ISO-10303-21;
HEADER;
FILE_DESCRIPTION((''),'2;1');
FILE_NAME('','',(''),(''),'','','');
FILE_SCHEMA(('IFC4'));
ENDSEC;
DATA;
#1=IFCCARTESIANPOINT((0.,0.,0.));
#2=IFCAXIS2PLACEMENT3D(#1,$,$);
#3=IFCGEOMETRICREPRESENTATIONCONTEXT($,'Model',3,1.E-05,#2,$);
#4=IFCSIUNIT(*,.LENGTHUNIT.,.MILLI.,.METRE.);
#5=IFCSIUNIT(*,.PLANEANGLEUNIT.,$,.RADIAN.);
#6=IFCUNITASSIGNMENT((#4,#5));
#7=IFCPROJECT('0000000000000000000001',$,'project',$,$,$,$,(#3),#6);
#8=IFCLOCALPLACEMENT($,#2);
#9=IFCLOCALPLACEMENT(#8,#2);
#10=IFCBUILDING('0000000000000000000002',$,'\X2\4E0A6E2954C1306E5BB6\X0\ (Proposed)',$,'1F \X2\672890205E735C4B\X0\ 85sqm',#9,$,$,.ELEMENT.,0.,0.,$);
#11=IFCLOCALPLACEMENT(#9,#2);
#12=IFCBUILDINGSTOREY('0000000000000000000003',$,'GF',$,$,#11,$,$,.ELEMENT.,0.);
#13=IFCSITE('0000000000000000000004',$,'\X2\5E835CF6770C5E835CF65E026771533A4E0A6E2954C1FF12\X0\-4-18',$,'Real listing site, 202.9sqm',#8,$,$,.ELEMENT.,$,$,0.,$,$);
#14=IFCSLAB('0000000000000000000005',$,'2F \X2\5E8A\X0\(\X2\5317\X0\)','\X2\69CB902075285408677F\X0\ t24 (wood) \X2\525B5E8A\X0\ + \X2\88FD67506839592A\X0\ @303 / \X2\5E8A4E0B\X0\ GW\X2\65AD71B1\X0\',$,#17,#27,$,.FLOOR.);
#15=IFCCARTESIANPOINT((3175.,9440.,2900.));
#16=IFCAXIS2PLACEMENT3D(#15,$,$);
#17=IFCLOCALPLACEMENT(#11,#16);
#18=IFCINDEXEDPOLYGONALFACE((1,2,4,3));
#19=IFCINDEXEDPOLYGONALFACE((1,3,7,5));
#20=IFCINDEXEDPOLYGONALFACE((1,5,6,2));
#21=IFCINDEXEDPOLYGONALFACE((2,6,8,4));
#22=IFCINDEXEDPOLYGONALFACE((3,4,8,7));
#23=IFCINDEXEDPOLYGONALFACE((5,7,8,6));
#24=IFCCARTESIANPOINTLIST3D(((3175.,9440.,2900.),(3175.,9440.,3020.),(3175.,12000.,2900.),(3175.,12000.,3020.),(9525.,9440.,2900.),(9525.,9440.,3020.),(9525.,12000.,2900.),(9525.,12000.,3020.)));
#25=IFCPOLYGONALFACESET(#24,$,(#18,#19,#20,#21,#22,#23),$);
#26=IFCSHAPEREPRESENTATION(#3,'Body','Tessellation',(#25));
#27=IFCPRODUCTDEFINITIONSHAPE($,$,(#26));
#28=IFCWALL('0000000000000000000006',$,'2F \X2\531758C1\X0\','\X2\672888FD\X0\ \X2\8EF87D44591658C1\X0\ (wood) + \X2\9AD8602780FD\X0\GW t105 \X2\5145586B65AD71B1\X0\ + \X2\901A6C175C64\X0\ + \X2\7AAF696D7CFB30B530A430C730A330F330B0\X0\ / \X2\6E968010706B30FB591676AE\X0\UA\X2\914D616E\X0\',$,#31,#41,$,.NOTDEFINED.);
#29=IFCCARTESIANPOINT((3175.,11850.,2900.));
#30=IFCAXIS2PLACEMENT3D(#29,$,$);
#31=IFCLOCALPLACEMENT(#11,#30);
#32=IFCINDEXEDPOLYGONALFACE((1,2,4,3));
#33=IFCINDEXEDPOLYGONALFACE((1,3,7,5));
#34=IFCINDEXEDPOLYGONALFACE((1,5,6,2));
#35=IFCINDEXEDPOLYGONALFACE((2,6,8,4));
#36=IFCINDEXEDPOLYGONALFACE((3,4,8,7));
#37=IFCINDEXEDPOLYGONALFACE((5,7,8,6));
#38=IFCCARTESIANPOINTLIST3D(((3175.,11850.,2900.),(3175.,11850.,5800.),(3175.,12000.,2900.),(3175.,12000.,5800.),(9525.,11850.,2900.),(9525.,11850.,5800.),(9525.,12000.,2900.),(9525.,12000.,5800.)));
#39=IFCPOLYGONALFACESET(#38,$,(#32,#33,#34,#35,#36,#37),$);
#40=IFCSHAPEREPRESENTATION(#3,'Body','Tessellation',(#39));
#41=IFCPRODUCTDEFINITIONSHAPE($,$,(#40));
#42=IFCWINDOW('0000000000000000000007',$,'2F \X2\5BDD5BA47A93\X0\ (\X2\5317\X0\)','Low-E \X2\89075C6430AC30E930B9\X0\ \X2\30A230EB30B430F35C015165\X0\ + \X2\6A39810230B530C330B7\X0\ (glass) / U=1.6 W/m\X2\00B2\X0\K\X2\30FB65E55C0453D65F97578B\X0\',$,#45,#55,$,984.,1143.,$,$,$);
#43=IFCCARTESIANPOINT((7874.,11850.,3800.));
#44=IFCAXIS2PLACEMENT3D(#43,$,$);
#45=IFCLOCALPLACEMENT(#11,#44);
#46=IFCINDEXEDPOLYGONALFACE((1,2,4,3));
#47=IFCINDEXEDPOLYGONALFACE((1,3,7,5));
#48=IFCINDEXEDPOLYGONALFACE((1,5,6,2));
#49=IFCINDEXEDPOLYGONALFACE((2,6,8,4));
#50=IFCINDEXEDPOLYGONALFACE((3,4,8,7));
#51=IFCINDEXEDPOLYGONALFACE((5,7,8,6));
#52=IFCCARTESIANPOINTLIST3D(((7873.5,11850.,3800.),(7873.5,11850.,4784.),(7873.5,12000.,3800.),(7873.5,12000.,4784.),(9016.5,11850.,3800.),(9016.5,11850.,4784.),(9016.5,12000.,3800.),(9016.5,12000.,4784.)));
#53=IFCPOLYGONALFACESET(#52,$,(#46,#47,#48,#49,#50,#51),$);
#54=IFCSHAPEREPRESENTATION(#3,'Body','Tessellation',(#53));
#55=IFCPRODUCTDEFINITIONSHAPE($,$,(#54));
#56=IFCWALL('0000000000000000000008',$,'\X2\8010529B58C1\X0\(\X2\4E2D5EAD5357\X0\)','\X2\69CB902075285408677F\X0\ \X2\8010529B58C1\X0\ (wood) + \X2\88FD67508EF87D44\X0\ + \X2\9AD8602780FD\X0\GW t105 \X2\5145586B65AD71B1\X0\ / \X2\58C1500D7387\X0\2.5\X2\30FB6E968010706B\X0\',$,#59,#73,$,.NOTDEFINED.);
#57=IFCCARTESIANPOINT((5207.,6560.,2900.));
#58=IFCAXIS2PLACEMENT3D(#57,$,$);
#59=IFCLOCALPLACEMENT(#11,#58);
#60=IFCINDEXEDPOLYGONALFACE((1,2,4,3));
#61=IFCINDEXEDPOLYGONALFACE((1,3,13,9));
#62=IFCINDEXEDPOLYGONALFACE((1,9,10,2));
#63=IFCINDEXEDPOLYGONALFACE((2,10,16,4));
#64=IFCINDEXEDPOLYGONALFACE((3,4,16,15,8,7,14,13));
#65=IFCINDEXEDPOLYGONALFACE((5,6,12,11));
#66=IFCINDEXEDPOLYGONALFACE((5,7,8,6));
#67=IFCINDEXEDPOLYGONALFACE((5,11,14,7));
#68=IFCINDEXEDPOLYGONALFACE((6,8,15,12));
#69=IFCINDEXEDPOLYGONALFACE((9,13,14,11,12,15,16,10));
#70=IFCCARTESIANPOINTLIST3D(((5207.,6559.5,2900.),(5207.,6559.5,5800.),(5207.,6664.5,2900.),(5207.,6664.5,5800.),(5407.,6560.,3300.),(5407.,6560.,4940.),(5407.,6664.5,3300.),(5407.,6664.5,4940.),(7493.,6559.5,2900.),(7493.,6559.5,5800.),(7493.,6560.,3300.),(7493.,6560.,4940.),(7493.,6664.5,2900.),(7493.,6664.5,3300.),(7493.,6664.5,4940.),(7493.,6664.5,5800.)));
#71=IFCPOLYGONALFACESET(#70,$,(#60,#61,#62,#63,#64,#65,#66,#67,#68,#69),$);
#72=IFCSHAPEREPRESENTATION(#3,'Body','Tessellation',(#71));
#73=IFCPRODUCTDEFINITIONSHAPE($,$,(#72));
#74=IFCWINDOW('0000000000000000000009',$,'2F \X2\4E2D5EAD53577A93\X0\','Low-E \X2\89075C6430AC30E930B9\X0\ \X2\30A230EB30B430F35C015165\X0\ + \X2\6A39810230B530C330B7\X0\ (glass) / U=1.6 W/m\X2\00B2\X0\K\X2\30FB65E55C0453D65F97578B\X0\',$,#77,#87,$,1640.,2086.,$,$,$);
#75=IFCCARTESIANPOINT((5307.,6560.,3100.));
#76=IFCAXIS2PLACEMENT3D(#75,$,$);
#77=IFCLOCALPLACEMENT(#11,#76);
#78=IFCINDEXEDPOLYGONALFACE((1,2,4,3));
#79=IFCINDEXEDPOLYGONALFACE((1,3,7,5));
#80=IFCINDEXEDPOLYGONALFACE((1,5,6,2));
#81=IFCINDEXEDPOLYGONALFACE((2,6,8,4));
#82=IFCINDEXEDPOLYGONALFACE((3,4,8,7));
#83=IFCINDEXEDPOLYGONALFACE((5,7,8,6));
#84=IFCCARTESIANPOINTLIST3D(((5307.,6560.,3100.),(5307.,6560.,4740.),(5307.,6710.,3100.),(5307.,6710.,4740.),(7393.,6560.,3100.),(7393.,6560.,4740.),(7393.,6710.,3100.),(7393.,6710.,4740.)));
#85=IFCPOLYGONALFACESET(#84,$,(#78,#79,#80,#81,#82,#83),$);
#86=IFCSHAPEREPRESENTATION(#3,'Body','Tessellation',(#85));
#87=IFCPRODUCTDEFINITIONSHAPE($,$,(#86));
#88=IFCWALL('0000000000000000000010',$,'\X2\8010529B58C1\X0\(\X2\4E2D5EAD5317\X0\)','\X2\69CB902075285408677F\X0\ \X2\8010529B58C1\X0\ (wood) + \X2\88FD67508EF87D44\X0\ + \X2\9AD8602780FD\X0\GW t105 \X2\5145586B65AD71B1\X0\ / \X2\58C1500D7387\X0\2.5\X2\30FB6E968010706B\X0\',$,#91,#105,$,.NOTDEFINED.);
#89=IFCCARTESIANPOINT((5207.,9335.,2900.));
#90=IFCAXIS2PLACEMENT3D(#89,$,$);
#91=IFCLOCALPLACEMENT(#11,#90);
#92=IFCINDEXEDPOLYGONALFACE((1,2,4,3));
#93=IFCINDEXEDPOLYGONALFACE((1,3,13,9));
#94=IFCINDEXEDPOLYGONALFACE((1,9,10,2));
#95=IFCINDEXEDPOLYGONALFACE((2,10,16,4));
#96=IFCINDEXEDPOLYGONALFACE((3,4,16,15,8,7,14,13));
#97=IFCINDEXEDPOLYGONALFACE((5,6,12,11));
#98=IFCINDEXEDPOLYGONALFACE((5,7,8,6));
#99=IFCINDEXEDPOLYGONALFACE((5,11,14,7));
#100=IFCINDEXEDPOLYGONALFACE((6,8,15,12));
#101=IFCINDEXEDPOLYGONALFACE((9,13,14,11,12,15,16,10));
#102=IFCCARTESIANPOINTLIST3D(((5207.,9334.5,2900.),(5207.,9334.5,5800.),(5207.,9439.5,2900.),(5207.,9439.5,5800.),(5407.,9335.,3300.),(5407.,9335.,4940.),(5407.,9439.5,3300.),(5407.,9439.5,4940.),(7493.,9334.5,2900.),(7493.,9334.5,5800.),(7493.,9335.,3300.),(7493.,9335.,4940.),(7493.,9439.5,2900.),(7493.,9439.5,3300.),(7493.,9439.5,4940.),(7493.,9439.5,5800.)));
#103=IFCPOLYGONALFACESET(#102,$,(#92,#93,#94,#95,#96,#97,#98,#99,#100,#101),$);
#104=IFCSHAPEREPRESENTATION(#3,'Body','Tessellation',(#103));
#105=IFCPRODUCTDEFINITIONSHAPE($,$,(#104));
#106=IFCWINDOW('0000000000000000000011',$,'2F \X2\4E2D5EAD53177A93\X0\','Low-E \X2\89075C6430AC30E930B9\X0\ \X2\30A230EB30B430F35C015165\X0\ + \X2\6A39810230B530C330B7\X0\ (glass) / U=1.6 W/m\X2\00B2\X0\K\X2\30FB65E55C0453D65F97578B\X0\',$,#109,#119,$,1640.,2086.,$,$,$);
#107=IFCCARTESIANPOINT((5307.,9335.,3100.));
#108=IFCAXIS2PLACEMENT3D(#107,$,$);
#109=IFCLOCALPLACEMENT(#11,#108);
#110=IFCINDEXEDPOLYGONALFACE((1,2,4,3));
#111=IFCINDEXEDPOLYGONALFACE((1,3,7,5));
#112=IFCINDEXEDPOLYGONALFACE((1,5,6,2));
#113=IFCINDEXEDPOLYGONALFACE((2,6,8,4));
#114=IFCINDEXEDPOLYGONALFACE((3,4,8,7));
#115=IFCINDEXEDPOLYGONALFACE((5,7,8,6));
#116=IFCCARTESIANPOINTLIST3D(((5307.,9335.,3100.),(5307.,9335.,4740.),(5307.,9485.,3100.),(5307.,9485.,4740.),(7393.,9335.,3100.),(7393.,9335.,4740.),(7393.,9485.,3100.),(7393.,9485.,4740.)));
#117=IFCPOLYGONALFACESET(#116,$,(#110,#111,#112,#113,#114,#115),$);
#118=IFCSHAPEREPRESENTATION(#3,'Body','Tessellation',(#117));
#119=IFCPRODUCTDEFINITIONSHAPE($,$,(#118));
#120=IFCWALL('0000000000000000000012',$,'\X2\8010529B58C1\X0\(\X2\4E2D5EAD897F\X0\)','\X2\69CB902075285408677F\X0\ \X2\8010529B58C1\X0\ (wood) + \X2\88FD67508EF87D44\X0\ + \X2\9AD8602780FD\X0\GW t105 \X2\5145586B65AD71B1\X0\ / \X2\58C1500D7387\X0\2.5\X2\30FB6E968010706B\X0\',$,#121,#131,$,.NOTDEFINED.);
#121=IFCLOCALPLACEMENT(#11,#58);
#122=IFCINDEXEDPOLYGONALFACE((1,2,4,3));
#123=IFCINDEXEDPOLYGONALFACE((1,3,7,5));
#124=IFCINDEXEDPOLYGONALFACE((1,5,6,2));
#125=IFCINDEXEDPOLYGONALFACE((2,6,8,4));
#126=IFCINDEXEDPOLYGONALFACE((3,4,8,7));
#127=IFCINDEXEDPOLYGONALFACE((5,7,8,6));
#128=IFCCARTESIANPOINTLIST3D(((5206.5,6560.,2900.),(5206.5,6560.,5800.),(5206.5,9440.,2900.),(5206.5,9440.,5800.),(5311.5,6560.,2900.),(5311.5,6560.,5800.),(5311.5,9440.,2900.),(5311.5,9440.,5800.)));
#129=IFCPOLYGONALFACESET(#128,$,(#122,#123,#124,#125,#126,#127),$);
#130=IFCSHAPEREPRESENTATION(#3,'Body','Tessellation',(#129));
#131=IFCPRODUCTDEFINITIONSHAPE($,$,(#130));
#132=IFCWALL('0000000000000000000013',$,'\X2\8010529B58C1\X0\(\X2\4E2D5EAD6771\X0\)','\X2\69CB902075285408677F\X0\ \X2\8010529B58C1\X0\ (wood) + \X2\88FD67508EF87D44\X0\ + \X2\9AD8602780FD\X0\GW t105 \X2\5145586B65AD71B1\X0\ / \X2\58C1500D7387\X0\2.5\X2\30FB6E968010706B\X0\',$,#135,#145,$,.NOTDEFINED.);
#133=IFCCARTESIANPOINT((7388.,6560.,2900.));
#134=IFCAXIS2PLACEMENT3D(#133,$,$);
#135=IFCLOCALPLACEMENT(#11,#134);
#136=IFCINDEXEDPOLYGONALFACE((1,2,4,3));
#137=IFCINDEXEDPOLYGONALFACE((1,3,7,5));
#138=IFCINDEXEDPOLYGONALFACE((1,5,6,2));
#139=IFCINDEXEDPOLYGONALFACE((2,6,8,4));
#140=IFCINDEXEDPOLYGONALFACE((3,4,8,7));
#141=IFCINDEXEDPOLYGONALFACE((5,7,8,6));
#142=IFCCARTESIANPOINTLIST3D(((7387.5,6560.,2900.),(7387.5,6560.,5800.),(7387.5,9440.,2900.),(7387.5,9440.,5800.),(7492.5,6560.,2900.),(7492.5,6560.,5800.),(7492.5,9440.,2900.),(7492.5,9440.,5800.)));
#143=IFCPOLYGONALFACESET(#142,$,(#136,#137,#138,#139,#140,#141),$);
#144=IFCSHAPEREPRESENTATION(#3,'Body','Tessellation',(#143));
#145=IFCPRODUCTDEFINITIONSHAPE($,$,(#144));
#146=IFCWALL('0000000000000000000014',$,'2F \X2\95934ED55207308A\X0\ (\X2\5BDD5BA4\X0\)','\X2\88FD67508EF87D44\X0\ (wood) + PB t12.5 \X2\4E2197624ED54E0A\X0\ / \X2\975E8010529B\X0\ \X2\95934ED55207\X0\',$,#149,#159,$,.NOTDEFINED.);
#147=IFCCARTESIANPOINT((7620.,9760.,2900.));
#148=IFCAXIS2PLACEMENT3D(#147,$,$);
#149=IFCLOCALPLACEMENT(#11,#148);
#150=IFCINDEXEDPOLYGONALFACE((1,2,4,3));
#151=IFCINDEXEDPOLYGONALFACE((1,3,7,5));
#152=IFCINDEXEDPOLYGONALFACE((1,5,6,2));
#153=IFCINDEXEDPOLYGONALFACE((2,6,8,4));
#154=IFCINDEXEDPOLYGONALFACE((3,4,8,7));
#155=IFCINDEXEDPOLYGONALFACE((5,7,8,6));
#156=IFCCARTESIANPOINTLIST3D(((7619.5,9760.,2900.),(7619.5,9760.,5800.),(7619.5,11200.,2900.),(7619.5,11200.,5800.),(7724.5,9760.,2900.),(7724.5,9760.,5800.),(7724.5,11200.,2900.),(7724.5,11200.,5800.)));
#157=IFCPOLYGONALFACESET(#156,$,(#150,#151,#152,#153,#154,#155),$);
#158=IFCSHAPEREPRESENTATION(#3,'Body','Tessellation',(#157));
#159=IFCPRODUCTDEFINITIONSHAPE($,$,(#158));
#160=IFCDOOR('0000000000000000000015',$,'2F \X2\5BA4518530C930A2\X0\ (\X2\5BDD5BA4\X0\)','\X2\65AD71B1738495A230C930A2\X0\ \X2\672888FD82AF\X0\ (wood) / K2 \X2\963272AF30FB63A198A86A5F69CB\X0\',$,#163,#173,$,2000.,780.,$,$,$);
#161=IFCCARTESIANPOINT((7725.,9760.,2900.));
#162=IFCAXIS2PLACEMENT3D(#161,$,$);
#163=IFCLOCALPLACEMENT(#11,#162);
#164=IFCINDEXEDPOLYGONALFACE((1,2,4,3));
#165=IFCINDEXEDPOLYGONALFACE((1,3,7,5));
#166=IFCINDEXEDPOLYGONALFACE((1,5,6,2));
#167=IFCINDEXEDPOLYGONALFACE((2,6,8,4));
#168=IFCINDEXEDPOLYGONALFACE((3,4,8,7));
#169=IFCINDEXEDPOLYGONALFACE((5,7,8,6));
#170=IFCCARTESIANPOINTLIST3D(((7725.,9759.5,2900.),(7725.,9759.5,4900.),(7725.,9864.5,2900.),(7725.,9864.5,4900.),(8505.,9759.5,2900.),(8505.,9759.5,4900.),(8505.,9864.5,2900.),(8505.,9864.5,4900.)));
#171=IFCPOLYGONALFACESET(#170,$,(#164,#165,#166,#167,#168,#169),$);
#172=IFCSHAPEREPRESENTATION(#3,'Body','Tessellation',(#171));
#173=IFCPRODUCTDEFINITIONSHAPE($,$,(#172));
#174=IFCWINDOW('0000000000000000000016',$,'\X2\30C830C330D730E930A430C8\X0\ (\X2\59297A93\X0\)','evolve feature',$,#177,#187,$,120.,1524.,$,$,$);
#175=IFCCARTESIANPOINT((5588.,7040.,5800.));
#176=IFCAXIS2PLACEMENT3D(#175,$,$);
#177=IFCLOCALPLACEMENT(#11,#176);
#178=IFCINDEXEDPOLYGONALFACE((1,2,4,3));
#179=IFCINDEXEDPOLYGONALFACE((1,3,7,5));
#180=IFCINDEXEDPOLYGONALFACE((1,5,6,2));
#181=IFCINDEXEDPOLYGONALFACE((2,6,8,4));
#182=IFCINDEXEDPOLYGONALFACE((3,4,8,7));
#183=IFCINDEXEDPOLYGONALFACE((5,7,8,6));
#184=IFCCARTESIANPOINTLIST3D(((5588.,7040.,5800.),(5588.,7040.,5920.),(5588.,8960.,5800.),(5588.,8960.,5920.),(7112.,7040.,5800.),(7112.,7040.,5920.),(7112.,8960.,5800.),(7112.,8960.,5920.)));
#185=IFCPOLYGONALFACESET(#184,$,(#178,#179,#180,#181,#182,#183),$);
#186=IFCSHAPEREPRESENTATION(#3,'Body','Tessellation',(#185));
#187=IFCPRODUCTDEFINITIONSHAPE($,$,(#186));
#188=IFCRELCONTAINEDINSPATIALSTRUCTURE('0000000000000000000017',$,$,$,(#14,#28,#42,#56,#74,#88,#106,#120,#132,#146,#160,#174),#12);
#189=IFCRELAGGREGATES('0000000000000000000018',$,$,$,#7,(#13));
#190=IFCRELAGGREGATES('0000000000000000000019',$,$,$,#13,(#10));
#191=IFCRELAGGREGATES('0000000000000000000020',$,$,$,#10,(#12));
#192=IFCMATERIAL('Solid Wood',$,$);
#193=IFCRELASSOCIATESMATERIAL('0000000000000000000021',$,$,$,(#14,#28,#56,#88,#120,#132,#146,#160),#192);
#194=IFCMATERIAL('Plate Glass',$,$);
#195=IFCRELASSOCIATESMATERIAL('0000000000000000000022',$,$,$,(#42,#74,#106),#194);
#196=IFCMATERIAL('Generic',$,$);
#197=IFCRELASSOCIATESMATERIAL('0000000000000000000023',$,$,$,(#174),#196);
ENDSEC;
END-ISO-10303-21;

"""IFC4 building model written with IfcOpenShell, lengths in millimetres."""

from ifc_helpers import new_model, si_unit, frame, frame_2d, origin, place, context, project, spatial, rectangle, extrude, material, element, fill, save


model = new_model("IFC4")

# Units and contexts
model_context = context("Model", 3, precision=1e-05, world=origin())
ifc_project = project(units=[si_unit("LENGTHUNIT", "METRE", prefix="MILLI"), si_unit("PLANEANGLEUNIT", "RADIAN")], contexts=[model_context])

# Site, building, storey
site_placement = place(None, origin())
site = spatial("IfcSite", under=ifc_project, at=site_placement, Name="広島県広島市東区上温品２-4-18", ObjectType="Real listing site, 202.9sqm", CompositionType="ELEMENT", RefElevation=0.0)
building_placement = place(site_placement, origin())
building = spatial("IfcBuilding", under=site, at=building_placement, Name="上温品の家 (Proposed)", ObjectType="1F 木造平屋 85sqm", CompositionType="ELEMENT", ElevationOfRefHeight=0.0, ElevationOfTerrain=0.0)
storey_placement = place(building_placement, origin())
storey = spatial("IfcBuildingStorey", under=building, at=storey_placement, Name="GF", CompositionType="ELEMENT", Elevation=0.0)

# Slab
ifc_material_1 = material(Name="Solid Wood")
slab_placement = place(storey_placement, frame((3175.0, 9440.0, 2900.0)))
element("IfcSlab", 1, at=slab_placement, inside=storey, material=ifc_material_1, Name="2F 床(北)", Description="構造用合板 t24 (wood) 剛床 + 製材根太 @303 / 床下 GW断熱", PredefinedType="FLOOR", context=model_context, shape_type="SweptSolid", body=[
    extrude(rectangle(XDim=6350.0, YDim=2560.0, at=frame_2d((3175.0, 1280.0))), frame((3175.0, 9440.0, 2900.0)), (0.0, 0.0, 1.0), 120.0),
])

# Walls, openings, windows
wall_1_placement = place(storey_placement, frame((3175.0, 11850.0, 2900.0)))
wall_1 = element("IfcWall", 2, at=wall_1_placement, inside=storey, material=ifc_material_1, Name="2F 北壁", Description="木製 軸組外壁 (wood) + 高性能GW t105 充填断熱 + 通気層 + 窯業系サイディング / 準耐火・外皮UA配慮", PredefinedType="NOTDEFINED", context=model_context, shape_type="SweptSolid", body=[
    extrude(rectangle(XDim=6350.0, YDim=150.0, at=frame_2d((3175.0, 75.0))), frame((3175.0, 11850.0, 2900.0)), (0.0, 0.0, 1.0), 2900.0),
])
opening_1_placement = place(storey_placement, frame((7874.0, 11850.0, 3800.0)))
opening_1 = element("IfcOpeningElement", 3, at=opening_1_placement, cuts=wall_1, PredefinedType="NOTDEFINED", context=model_context, shape_type="SweptSolid", body=[
    extrude(rectangle(XDim=1143.0, YDim=150.0, at=frame_2d((571.0, 75.0))), frame((7874.0, 11850.0, 3800.0)), (0.0, 0.0, 1.0), 984.0),
])
ifc_material_2 = material(Name="Plate Glass")
window_1_placement = place(storey_placement, frame((7874.0, 11850.0, 3800.0)))
window_1 = element("IfcWindow", 4, at=window_1_placement, inside=storey, material=ifc_material_2, Name="2F 寝室窓 (北)", Description="Low-E 複層ガラス アルゴン封入 + 樹脂サッシ (glass) / U=1.6 W/m²K・日射取得型", OverallHeight=984.0, OverallWidth=1143.0, context=model_context, shape_type="SweptSolid", body=[
    extrude(rectangle(XDim=1143.0, YDim=150.0, at=frame_2d((571.0, 75.0))), frame((7874.0, 11850.0, 3800.0)), (0.0, 0.0, 1.0), 984.0),
])
fill(opening_1, window_1)
wall_2_placement = place(storey_placement, frame((5207.0, 6560.0, 2900.0)))
wall_2 = element("IfcWall", 5, at=wall_2_placement, inside=storey, material=ifc_material_1, Name="耐力壁(中庭南)", Description="構造用合板 耐力壁 (wood) + 製材軸組 + 高性能GW t105 充填断熱 / 壁倍率2.5・準耐火", PredefinedType="NOTDEFINED", context=model_context, shape_type="SweptSolid", body=[
    extrude(rectangle(XDim=2286.0, YDim=105.0, at=frame_2d((1143.0, 52.0))), frame((5207.0, 6560.0, 2900.0)), (0.0, 0.0, 1.0), 2900.0),
])
opening_2_placement = place(storey_placement, frame((5307.0, 6560.0, 3100.0)))
opening_2 = element("IfcOpeningElement", 6, at=opening_2_placement, cuts=wall_2, PredefinedType="NOTDEFINED", context=model_context, shape_type="SweptSolid", body=[
    extrude(rectangle(XDim=2086.0, YDim=150.0, at=frame_2d((1043.0, 75.0))), frame((5307.0, 6560.0, 3100.0)), (0.0, 0.0, 1.0), 1640.0),
])
window_2_placement = place(storey_placement, frame((5307.0, 6560.0, 3100.0)))
window_2 = element("IfcWindow", 7, at=window_2_placement, inside=storey, material=ifc_material_2, Name="2F 中庭南窓", Description="Low-E 複層ガラス アルゴン封入 + 樹脂サッシ (glass) / U=1.6 W/m²K・日射取得型", OverallHeight=1640.0, OverallWidth=2086.0, context=model_context, shape_type="SweptSolid", body=[
    extrude(rectangle(XDim=2086.0, YDim=150.0, at=frame_2d((1043.0, 75.0))), frame((5307.0, 6560.0, 3100.0)), (0.0, 0.0, 1.0), 1640.0),
])
fill(opening_2, window_2)
wall_3_placement = place(storey_placement, frame((5207.0, 9335.0, 2900.0)))
wall_3 = element("IfcWall", 8, at=wall_3_placement, inside=storey, material=ifc_material_1, Name="耐力壁(中庭北)", Description="構造用合板 耐力壁 (wood) + 製材軸組 + 高性能GW t105 充填断熱 / 壁倍率2.5・準耐火", PredefinedType="NOTDEFINED", context=model_context, shape_type="SweptSolid", body=[
    extrude(rectangle(XDim=2286.0, YDim=105.0, at=frame_2d((1143.0, 52.0))), frame((5207.0, 9335.0, 2900.0)), (0.0, 0.0, 1.0), 2900.0),
])
opening_3_placement = place(storey_placement, frame((5307.0, 9335.0, 3100.0)))
opening_3 = element("IfcOpeningElement", 9, at=opening_3_placement, cuts=wall_3, PredefinedType="NOTDEFINED", context=model_context, shape_type="SweptSolid", body=[
    extrude(rectangle(XDim=2086.0, YDim=150.0, at=frame_2d((1043.0, 75.0))), frame((5307.0, 9335.0, 3100.0)), (0.0, 0.0, 1.0), 1640.0),
])
window_3_placement = place(storey_placement, frame((5307.0, 9335.0, 3100.0)))
window_3 = element("IfcWindow", 10, at=window_3_placement, inside=storey, material=ifc_material_2, Name="2F 中庭北窓", Description="Low-E 複層ガラス アルゴン封入 + 樹脂サッシ (glass) / U=1.6 W/m²K・日射取得型", OverallHeight=1640.0, OverallWidth=2086.0, context=model_context, shape_type="SweptSolid", body=[
    extrude(rectangle(XDim=2086.0, YDim=150.0, at=frame_2d((1043.0, 75.0))), frame((5307.0, 9335.0, 3100.0)), (0.0, 0.0, 1.0), 1640.0),
])
fill(opening_3, window_3)

# Walls
wall_4_placement = place(storey_placement, frame((5207.0, 6560.0, 2900.0)))
element("IfcWall", 11, at=wall_4_placement, inside=storey, material=ifc_material_1, Name="耐力壁(中庭西)", Description="構造用合板 耐力壁 (wood) + 製材軸組 + 高性能GW t105 充填断熱 / 壁倍率2.5・準耐火", PredefinedType="NOTDEFINED", context=model_context, shape_type="SweptSolid", body=[
    extrude(rectangle(XDim=105.0, YDim=2880.0, at=frame_2d((52.0, 1440.0))), frame((5207.0, 6560.0, 2900.0)), (0.0, 0.0, 1.0), 2900.0),
])
wall_5_placement = place(storey_placement, frame((7388.0, 6560.0, 2900.0)))
element("IfcWall", 12, at=wall_5_placement, inside=storey, material=ifc_material_1, Name="耐力壁(中庭東)", Description="構造用合板 耐力壁 (wood) + 製材軸組 + 高性能GW t105 充填断熱 / 壁倍率2.5・準耐火", PredefinedType="NOTDEFINED", context=model_context, shape_type="SweptSolid", body=[
    extrude(rectangle(XDim=105.0, YDim=2880.0, at=frame_2d((52.0, 1440.0))), frame((7388.0, 6560.0, 2900.0)), (0.0, 0.0, 1.0), 2900.0),
])
wall_6_placement = place(storey_placement, frame((7620.0, 9760.0, 2900.0)))
element("IfcWall", 13, at=wall_6_placement, inside=storey, material=ifc_material_1, Name="2F 間仕切り (寝室)", Description="製材軸組 (wood) + PB t12.5 両面仕上 / 非耐力 間仕切", PredefinedType="NOTDEFINED", context=model_context, shape_type="SweptSolid", body=[
    extrude(rectangle(XDim=105.0, YDim=1440.0, at=frame_2d((52.0, 720.0))), frame((7620.0, 9760.0, 2900.0)), (0.0, 0.0, 1.0), 2900.0),
])

# Door
door_placement = place(storey_placement, frame((7725.0, 9760.0, 2900.0)))
element("IfcDoor", 14, at=door_placement, inside=storey, material=ifc_material_1, Name="2F 室内ドア (寝室)", Description="断熱玄関ドア 木製芯 (wood) / K2 防犯・採風機構", OverallHeight=2000.0, OverallWidth=780.0, context=model_context, shape_type="SweptSolid", body=[
    extrude(rectangle(XDim=780.0, YDim=105.0, at=frame_2d((390.0, 52.0))), frame((7725.0, 9760.0, 2900.0)), (0.0, 0.0, 1.0), 2000.0),
])

# Window
ifc_material_3 = material(Name="Generic")
window_4_placement = place(storey_placement, frame((5588.0, 7040.0, 5800.0)))
element("IfcWindow", 15, at=window_4_placement, inside=storey, material=ifc_material_3, Name="トップライト (天窓)", Description="evolve feature", OverallHeight=120.0, OverallWidth=1524.0, context=model_context, shape_type="SweptSolid", body=[
    extrude(rectangle(XDim=1524.0, YDim=1920.0, at=frame_2d((762.0, 960.0))), frame((5588.0, 7040.0, 5800.0)), (0.0, 0.0, 1.0), 120.0),
])

save(model, "model.ifc")
